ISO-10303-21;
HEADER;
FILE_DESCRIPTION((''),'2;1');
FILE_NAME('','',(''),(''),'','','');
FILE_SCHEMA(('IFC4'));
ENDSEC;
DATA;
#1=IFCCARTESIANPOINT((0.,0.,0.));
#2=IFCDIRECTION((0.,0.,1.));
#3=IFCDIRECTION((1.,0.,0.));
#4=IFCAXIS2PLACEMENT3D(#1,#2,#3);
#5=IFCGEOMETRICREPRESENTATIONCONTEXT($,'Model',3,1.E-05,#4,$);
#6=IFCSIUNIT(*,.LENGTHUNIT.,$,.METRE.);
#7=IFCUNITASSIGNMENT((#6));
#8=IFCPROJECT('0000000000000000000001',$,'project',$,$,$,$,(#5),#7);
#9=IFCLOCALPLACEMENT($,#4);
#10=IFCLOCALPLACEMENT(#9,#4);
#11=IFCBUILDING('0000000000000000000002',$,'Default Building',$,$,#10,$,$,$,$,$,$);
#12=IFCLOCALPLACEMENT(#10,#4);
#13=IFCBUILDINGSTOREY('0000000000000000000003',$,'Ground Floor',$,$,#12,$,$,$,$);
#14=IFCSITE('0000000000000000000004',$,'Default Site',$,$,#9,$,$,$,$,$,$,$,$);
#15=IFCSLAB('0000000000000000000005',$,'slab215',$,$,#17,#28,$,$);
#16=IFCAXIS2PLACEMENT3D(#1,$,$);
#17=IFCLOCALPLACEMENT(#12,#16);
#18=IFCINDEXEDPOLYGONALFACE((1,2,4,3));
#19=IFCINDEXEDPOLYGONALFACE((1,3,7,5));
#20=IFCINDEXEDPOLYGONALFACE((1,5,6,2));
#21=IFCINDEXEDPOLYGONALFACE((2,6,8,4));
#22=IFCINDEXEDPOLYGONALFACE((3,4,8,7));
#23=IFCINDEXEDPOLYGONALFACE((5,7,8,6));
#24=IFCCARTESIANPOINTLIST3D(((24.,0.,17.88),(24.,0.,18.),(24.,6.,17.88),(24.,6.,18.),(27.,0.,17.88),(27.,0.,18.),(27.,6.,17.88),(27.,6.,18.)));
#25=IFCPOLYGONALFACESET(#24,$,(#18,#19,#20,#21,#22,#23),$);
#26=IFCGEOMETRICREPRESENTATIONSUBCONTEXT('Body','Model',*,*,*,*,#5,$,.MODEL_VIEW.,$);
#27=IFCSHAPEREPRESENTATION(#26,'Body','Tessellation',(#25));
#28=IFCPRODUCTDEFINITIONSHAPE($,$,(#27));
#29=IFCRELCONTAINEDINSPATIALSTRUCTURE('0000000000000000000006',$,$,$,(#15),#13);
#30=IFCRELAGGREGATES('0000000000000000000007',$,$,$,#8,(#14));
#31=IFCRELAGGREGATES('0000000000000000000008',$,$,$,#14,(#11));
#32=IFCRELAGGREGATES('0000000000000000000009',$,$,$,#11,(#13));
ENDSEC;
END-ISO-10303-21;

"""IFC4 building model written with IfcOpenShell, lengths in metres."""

from ifc_helpers import new_model, si_unit, frame, origin_with_axes, place, context, subcontext, project, spatial, indexed_curve, outline, extrude, element, save


model = new_model("IFC4")

# Units and contexts
model_context = context("Model", 3, precision=1e-05, world=origin_with_axes())
body_context = subcontext(model_context, "Body", "Model", "MODEL_VIEW")
ifc_project = project(units=[si_unit("LENGTHUNIT", "METRE")], contexts=[model_context])

# Site, building, storey
site_placement = place(None, origin_with_axes())
site = spatial("IfcSite", under=ifc_project, at=site_placement, Name="Default Site")
building_placement = place(site_placement, origin_with_axes())
building = spatial("IfcBuilding", under=site, at=building_placement, Name="Default Building")
storey_placement = place(building_placement, origin_with_axes())
storey = spatial("IfcBuildingStorey", under=building, at=storey_placement, Name="Ground Floor")

# Slab
for number, where, z_axis, x_axis, name in (
    (1, (24.0, 0.0, 17.88), (0.0, 0.0, 1.0), (1.0, 0.0, 0.0), "slab215"),
):
    element("IfcSlab", number, at=place(storey_placement, frame(where, z_axis=z_axis, x_axis=x_axis)), inside=storey, Name=name, context=body_context, shape_type="SweptSolid", body=[
        extrude(outline(indexed_curve([(0.0, 0.0), (0.0, 6.0), (3.0, 6.0), (3.0, 0.0), (0.0, 0.0)], self_intersect=False)), origin_with_axes(), (0.0, 0.0, 1.0), 0.12),
    ])

save(model, "model.ifc")
